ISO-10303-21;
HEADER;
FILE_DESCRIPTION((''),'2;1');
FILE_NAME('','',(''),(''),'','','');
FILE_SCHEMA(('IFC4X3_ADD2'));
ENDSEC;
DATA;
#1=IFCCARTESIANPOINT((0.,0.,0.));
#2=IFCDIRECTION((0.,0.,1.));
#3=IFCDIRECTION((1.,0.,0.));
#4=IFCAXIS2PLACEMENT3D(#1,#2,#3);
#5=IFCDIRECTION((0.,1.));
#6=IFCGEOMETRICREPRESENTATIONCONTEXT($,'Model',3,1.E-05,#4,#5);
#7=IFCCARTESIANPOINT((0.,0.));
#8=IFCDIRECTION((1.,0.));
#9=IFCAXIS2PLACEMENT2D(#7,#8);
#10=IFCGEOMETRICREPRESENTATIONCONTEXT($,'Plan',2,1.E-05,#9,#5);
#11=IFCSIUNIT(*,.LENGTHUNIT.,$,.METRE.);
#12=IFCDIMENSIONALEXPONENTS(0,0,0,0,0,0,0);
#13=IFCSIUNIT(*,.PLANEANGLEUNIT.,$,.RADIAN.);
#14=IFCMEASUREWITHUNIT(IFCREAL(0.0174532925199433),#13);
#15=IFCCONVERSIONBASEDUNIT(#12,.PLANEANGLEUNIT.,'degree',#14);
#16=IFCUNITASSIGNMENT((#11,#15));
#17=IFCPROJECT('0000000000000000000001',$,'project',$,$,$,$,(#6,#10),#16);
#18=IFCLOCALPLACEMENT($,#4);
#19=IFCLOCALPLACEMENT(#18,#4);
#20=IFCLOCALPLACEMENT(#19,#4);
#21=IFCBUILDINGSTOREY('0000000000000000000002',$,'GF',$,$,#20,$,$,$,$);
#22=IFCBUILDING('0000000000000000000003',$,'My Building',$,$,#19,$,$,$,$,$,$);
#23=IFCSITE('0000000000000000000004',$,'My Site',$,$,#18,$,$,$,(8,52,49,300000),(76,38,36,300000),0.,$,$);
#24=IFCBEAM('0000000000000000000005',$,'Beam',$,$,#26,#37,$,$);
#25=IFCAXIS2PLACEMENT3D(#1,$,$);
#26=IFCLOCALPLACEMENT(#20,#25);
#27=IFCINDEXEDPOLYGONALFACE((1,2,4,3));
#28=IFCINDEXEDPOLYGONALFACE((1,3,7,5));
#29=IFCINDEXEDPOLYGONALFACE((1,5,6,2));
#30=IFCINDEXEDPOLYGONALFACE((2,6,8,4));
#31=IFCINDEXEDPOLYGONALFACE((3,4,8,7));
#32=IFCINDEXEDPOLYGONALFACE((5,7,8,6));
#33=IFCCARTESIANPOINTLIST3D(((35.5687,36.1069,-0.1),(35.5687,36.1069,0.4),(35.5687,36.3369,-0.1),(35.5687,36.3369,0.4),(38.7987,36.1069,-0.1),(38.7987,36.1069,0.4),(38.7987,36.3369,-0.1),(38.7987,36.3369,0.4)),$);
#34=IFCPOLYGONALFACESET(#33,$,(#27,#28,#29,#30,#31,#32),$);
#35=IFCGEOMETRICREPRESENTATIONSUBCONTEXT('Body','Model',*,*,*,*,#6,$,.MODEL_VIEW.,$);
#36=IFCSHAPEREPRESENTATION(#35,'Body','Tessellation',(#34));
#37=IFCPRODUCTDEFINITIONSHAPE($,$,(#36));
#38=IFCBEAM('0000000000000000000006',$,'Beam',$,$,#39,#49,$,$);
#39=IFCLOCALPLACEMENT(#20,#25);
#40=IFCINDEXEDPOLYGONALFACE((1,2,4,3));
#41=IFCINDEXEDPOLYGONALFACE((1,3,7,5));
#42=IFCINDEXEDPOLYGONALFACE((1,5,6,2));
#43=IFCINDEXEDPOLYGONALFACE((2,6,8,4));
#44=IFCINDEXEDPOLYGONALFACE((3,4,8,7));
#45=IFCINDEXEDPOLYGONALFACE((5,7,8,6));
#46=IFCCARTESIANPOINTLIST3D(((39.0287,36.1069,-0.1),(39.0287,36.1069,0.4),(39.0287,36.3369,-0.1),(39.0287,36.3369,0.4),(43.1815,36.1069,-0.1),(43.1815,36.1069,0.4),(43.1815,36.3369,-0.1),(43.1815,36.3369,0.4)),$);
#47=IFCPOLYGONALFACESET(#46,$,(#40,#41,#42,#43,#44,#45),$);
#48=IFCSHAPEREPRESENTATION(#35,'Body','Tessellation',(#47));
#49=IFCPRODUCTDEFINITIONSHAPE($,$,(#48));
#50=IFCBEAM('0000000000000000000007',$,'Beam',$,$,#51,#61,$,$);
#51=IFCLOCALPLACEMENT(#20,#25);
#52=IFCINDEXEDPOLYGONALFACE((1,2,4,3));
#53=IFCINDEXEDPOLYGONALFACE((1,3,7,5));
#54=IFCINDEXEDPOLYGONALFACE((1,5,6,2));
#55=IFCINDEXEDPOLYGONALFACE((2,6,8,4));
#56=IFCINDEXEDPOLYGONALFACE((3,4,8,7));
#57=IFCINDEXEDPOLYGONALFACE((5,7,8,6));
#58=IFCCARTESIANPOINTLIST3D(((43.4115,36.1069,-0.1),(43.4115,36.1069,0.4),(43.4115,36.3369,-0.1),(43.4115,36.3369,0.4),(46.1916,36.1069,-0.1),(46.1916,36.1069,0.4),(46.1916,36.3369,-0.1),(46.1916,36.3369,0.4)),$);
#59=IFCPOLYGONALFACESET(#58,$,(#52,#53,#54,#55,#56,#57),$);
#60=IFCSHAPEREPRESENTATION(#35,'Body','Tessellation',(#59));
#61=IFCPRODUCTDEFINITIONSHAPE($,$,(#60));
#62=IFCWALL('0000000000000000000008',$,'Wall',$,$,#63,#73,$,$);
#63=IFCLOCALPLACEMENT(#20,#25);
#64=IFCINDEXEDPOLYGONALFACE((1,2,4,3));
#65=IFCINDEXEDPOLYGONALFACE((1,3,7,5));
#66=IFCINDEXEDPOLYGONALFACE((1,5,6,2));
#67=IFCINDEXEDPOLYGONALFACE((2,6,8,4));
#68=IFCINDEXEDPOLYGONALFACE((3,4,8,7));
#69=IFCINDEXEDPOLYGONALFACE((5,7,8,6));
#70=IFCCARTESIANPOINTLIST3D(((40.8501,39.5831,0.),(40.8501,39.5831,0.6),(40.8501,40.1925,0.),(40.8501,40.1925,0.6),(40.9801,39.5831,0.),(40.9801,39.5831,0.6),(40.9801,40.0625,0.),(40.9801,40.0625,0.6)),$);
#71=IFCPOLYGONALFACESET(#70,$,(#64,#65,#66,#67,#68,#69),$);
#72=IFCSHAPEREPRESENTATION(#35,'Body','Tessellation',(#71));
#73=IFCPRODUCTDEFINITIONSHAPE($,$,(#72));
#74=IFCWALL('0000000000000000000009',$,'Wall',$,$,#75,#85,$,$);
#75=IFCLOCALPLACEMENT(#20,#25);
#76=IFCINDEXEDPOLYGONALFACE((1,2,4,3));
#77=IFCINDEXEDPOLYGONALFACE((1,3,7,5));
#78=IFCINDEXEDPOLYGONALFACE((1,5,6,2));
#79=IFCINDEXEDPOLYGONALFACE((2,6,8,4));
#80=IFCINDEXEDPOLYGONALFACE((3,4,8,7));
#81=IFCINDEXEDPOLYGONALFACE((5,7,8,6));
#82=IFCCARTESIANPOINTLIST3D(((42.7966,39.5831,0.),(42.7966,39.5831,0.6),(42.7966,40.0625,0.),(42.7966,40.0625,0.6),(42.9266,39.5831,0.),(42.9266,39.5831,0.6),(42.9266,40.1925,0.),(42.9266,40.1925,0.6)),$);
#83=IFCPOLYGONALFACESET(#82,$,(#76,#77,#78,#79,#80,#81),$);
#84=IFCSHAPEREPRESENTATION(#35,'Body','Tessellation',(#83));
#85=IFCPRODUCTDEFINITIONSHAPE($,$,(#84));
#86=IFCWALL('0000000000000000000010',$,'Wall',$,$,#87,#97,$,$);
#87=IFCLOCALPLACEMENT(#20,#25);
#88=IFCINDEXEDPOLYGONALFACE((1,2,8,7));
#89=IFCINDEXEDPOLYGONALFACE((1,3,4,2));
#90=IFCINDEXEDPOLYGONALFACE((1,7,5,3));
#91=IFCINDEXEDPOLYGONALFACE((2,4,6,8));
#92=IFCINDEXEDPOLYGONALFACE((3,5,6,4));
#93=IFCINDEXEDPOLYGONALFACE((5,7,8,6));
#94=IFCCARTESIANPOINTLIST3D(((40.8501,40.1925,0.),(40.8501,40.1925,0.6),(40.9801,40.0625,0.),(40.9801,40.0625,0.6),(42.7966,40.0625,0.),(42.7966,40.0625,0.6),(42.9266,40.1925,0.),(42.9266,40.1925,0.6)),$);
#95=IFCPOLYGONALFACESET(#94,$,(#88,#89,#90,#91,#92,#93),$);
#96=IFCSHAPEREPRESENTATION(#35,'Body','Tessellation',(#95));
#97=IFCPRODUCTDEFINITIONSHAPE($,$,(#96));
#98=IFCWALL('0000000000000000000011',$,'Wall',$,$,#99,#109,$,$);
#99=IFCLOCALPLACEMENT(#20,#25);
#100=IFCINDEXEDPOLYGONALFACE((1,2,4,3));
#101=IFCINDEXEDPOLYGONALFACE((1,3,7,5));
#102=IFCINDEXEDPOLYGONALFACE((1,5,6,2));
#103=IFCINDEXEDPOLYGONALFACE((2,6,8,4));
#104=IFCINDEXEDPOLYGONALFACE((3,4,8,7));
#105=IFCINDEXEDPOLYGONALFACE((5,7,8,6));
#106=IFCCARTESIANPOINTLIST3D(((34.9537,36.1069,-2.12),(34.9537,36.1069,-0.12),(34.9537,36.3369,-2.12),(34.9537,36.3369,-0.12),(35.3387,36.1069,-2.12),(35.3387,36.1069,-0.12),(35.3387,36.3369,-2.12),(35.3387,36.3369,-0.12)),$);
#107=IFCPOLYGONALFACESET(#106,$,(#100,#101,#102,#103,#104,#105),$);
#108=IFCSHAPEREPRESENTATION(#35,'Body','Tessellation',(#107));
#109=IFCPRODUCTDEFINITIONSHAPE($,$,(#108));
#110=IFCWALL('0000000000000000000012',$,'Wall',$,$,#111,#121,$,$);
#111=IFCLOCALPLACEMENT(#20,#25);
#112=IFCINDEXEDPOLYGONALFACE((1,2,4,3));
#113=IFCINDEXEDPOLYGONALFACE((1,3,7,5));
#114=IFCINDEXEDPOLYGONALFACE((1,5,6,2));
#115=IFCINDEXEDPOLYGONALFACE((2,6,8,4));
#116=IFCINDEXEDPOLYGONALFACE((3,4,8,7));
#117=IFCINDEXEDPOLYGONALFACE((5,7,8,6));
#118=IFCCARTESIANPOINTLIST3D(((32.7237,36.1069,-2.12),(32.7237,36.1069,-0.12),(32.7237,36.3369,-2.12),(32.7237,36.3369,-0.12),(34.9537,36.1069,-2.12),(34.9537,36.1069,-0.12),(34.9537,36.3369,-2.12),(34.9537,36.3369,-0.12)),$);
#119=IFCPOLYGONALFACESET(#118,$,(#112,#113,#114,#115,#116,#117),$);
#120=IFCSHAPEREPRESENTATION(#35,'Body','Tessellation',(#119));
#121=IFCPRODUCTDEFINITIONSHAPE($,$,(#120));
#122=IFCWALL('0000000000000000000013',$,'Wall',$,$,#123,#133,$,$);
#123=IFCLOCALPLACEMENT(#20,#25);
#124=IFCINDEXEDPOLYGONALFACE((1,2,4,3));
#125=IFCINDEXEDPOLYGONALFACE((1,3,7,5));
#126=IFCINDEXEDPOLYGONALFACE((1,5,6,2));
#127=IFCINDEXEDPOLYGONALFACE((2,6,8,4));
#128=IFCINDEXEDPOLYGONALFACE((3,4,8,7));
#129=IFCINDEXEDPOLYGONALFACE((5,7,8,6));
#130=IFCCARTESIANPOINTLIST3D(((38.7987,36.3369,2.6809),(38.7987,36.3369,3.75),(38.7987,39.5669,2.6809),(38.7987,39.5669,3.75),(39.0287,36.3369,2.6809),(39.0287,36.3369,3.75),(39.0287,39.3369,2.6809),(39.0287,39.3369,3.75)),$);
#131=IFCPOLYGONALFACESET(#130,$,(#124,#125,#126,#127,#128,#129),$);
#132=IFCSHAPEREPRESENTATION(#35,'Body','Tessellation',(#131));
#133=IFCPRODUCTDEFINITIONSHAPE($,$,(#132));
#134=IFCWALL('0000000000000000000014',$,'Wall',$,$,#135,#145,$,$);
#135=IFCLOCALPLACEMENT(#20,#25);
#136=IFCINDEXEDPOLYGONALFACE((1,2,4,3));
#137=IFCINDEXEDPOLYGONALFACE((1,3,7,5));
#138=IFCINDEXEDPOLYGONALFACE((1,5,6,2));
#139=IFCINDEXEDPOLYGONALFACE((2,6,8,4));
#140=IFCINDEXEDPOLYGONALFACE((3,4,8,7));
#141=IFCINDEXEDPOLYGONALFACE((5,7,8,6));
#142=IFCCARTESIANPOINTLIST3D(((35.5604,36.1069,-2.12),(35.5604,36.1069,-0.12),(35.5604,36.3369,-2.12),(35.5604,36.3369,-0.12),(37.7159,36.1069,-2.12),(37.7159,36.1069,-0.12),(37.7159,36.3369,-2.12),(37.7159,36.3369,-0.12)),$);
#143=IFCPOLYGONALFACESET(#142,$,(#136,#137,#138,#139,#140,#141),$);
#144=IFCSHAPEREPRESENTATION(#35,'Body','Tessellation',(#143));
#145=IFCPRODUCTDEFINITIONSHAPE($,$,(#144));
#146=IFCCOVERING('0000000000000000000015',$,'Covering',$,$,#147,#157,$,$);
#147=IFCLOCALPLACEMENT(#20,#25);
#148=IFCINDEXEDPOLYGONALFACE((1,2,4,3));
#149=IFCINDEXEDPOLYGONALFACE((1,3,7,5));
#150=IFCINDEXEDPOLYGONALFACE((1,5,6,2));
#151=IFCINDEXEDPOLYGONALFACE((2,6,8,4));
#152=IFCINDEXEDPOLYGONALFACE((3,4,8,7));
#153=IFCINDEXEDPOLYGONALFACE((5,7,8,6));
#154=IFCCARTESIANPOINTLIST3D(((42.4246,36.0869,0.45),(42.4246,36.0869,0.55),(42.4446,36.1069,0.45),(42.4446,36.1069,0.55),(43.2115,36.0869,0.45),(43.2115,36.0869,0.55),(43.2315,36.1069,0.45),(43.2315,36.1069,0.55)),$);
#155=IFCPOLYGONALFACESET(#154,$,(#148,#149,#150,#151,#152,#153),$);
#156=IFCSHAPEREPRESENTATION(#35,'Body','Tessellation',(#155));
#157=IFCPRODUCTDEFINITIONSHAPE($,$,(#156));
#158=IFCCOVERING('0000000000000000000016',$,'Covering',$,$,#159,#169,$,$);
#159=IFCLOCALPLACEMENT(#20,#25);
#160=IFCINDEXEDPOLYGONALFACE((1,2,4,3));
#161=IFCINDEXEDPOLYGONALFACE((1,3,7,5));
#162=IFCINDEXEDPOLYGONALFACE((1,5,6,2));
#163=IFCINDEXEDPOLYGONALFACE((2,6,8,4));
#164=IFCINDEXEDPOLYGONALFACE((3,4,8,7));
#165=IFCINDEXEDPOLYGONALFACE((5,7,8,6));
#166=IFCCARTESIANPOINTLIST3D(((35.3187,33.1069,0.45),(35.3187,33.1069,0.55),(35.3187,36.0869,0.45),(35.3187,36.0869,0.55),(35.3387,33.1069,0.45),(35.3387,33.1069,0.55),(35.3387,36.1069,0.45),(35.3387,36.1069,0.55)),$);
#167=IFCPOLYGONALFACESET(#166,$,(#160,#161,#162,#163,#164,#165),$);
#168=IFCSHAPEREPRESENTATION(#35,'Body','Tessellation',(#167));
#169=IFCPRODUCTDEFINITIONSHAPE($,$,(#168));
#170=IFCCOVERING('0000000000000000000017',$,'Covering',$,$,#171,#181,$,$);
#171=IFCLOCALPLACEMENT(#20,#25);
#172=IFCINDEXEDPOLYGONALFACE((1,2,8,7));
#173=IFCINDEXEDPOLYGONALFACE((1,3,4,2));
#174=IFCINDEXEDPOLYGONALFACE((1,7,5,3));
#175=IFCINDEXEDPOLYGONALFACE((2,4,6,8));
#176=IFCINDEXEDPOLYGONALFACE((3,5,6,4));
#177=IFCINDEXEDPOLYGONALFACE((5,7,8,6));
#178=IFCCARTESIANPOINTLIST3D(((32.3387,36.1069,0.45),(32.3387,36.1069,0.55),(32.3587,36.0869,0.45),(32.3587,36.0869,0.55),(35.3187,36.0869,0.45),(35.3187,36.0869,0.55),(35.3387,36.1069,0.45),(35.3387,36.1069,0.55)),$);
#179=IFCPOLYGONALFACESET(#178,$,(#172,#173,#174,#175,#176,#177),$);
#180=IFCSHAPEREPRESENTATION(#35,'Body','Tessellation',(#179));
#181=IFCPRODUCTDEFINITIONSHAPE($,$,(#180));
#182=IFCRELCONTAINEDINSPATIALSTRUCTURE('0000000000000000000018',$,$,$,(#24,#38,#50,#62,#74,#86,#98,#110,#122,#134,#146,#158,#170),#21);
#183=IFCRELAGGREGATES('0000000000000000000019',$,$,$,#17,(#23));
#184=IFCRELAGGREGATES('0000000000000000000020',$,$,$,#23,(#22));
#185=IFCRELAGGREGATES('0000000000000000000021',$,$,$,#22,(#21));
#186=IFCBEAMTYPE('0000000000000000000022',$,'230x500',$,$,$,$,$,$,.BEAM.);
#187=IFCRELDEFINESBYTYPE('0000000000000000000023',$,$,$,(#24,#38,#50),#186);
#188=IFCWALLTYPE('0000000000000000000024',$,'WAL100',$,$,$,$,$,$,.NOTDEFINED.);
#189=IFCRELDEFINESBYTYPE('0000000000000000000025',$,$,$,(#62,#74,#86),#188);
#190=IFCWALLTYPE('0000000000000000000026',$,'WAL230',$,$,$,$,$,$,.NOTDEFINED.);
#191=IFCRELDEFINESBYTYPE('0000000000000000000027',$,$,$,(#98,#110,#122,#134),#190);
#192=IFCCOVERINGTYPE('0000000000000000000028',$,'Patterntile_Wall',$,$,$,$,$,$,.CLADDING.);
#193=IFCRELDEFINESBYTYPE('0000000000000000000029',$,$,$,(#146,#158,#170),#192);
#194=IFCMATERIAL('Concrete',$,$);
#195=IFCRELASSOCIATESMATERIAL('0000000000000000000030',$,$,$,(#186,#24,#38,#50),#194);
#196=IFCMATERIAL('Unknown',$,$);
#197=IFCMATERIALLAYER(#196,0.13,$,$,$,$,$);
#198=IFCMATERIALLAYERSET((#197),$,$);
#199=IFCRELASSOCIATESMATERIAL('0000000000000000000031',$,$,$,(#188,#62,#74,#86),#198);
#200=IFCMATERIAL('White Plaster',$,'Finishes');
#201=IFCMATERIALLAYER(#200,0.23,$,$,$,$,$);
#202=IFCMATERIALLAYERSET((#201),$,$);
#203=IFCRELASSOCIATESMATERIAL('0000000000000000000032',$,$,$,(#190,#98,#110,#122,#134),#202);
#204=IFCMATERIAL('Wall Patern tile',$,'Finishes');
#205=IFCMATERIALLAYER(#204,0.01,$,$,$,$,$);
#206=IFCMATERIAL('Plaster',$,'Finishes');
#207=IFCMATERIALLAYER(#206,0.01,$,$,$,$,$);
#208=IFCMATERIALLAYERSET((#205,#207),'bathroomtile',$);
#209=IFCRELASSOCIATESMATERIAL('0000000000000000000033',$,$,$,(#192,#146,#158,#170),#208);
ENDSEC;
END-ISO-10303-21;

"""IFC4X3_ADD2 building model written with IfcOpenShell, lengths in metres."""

from ifc_helpers import new_model, entity, si_unit, converted_unit, direction, frame, origin_with_axes, origin_2d_with_axis, place, context, subcontext, project, spatial, line, indexed_curve, rectangle, outline, extrude, material, layer, layer_set, layer_usage, material_profile, profile_set, profile_usage, type_object, element, save


model = new_model("IFC4X3_ADD2")

# Units and contexts
model_context = context("Model", 3, precision=1e-05, world=origin_with_axes(), true_north=direction((0.0, 1.0)))
plan_context = context("Plan", 2, precision=1e-05, world=origin_2d_with_axis(), true_north=direction((0.0, 1.0)))
body_context_1 = subcontext(model_context, "Body", "Model", "MODEL_VIEW")
ifc_project = project(units=[si_unit("LENGTHUNIT", "METRE"), converted_unit("PLANEANGLEUNIT", "degree", entity("IfcReal", 0.0174532925199433), si_unit("PLANEANGLEUNIT", "RADIAN"), dimensions=[0, 0, 0, 0, 0, 0, 0])], contexts=[model_context, plan_context])

# Site, building, storey
site_placement = place(None, origin_with_axes())
site = spatial("IfcSite", under=ifc_project, at=site_placement, Name="My Site", RefLatitude=(8, 52, 49, 300000), RefLongitude=(76, 38, 36, 300000), RefElevation=0.0)
building_placement = place(site_placement, origin_with_axes())
building = spatial("IfcBuilding", under=site, at=building_placement, Name="My Building")
storey_placement = place(building_placement, origin_with_axes())
storey = spatial("IfcBuildingStorey", under=building, at=storey_placement, Name="GF")

# Beams
ifc_material_1 = material(Name="Concrete")
ifc_material_profile = material_profile(ifc_material_1, rectangle(XDim=0.23, YDim=0.5))
ifc_profile_set = profile_set([ifc_material_profile])
ifc_profile_usage_1 = profile_usage(ifc_profile_set, cardinal=5)
beam_type = type_object("IfcBeamType", Name="230x500", PredefinedType="BEAM", material=ifc_profile_set)
beam_1_placement = place(storey_placement, frame((35.5687, 36.2219, 0.15), z_axis=(1.0, 0.0, 0.0), x_axis=(0.0, 1.0, 0.0)))
element("IfcBeam", 1, at=beam_1_placement, inside=storey, type_object=beam_type, material=ifc_profile_usage_1, Name="Beam", context=body_context_1, shape_type="SweptSolid", body=[
    extrude(rectangle(XDim=0.23, YDim=0.5), origin_with_axes(), (0.0, 0.0, 1.0), 3.23),
])
ifc_profile_usage_2 = profile_usage(ifc_profile_set, cardinal=5)
beam_2_placement = place(storey_placement, frame((39.0287, 36.2219, 0.15), z_axis=(1.0, 0.0, 0.0), x_axis=(0.0, 1.0, 0.0)))
element("IfcBeam", 2, at=beam_2_placement, inside=storey, type_object=beam_type, material=ifc_profile_usage_2, Name="Beam", context=body_context_1, shape_type="SweptSolid", body=[
    extrude(rectangle(XDim=0.23, YDim=0.5), origin_with_axes(), (0.0, 0.0, 1.0), 4.1528),
])
ifc_profile_usage_3 = profile_usage(ifc_profile_set, cardinal=5)
beam_3_placement = place(storey_placement, frame((43.4115, 36.2219, 0.15), z_axis=(1.0, 0.0, 0.0), x_axis=(0.0, 1.0, 0.0)))
element("IfcBeam", 3, at=beam_3_placement, inside=storey, type_object=beam_type, material=ifc_profile_usage_3, Name="Beam", context=body_context_1, shape_type="SweptSolid", body=[
    extrude(rectangle(XDim=0.23, YDim=0.5), origin_with_axes(), (0.0, 0.0, 1.0), 2.7801),
])

# Walls
ifc_material_2 = material(Name="Unknown")
ifc_layer_1 = layer(ifc_material_2, 0.13)
ifc_layer_set_1 = layer_set([ifc_layer_1])
ifc_layer_usage_1 = layer_usage(ifc_layer_set_1, "AXIS2", "POSITIVE", 0.0)
wall_type_1 = type_object("IfcWallType", Name="WAL100", PredefinedType="NOTDEFINED", material=ifc_layer_set_1)
wall_1_placement = place(storey_placement, frame((40.9801, 39.5831, 0.0), z_axis=(0.0, 0.0, 1.0), x_axis=(0.0, 1.0, 0.0)))
element("IfcWall", 4, at=wall_1_placement, inside=storey, type_object=wall_type_1, material=ifc_layer_usage_1, Name="Wall", context=body_context_1, shape_type="SweptSolid", body=[
    extrude(outline(indexed_curve([(0.0, 0.0), (0.0, 0.13), (0.6094, 0.13), (0.4794, 0.0)], segments=[line(1, 2, 3, 4, 1)])), origin_with_axes(), (0.0, 0.0, 1.0), 0.6),
])
ifc_layer_usage_2 = layer_usage(ifc_layer_set_1, "AXIS2", "POSITIVE", 0.0)
wall_2_placement = place(storey_placement, frame((42.9266, 39.5831, 0.0), z_axis=(0.0, 0.0, 1.0), x_axis=(0.0, 1.0, 0.0)))
element("IfcWall", 5, at=wall_2_placement, inside=storey, type_object=wall_type_1, material=ifc_layer_usage_2, Name="Wall", context=body_context_1, shape_type="SweptSolid", body=[
    extrude(outline(indexed_curve([(0.0, 0.0), (0.0, 0.13), (0.4794, 0.13), (0.6094, 0.0)], segments=[line(1, 2, 3, 4, 1)])), origin_with_axes(), (0.0, 0.0, 1.0), 0.6),
])
ifc_layer_usage_3 = layer_usage(ifc_layer_set_1, "AXIS2", "POSITIVE", 0.0)
wall_3_placement = place(storey_placement, frame((42.9266, 40.1925, 0.0), z_axis=(0.0, 0.0, 1.0), x_axis=(-1.0, 0.0, 0.0)))
element("IfcWall", 6, at=wall_3_placement, inside=storey, type_object=wall_type_1, material=ifc_layer_usage_3, Name="Wall", context=body_context_1, shape_type="SweptSolid", body=[
    extrude(outline(indexed_curve([(0.0, 0.0), (0.13, 0.13), (1.9464, 0.13), (2.0764, 0.0)], segments=[line(1, 2, 3, 4, 1)])), origin_with_axes(), (0.0, 0.0, 1.0), 0.6),
])

# Shared definitions
ifc_material_3 = material(Name="White Plaster", Category="Finishes")
ifc_layer_2 = layer(ifc_material_3, 0.23)
ifc_layer_set_2 = layer_set([ifc_layer_2])
wall_type_2 = type_object("IfcWallType", Name="WAL230", PredefinedType="NOTDEFINED", material=ifc_layer_set_2)

# Walls
ifc_layer_usage_4 = layer_usage(ifc_layer_set_2, "AXIS2", "POSITIVE", 0.0)
wall_4_placement = place(storey_placement, frame((35.3387, 36.3369, -2.12), z_axis=(0.0, 0.0, 1.0), x_axis=(-1.0, 0.0, 0.0)))
element("IfcWall", 7, at=wall_4_placement, inside=storey, type_object=wall_type_2, material=ifc_layer_usage_4, Name="Wall", context=body_context_1, shape_type="SweptSolid", body=[
    extrude(outline(indexed_curve([(0.0, 0.0), (0.0, 0.23), (0.385, 0.23), (0.385, 0.0)], segments=[line(1, 2, 3, 4, 1)])), origin_with_axes(), (0.0, 0.0, 1.0), 2.0),
])
ifc_layer_usage_5 = layer_usage(ifc_layer_set_2, "AXIS2", "POSITIVE", 0.0)
wall_5_placement = place(storey_placement, frame((34.9537, 36.3369, -2.12), z_axis=(0.0, 0.0, 1.0), x_axis=(-1.0, 0.0, 0.0)))
element("IfcWall", 8, at=wall_5_placement, inside=storey, type_object=wall_type_2, material=ifc_layer_usage_5, Name="Wall", context=body_context_1, shape_type="SweptSolid", body=[
    extrude(outline(indexed_curve([(0.0, 0.0), (0.0, 0.23), (2.23, 0.23), (2.23, 0.0)], segments=[line(1, 2, 3, 4, 1)])), origin_with_axes(), (0.0, 0.0, 1.0), 2.0),
])
ifc_layer_usage_6 = layer_usage(ifc_layer_set_2, "AXIS2", "POSITIVE", 0.0)
wall_6_placement = place(storey_placement, frame((39.0287, 36.3369, 2.6809), z_axis=(0.0, 0.0, 1.0), x_axis=(0.000001, 1.0, 0.0)))
element("IfcWall", 9, at=wall_6_placement, inside=storey, type_object=wall_type_2, material=ifc_layer_usage_6, Name="Wall", context=body_context_1, shape_type="SweptSolid", body=[
    extrude(outline(indexed_curve([(0.0, 0.0), (0.0, 0.23), (3.23, 0.23), (3.0, 0.0)], segments=[line(1, 2, 3, 4, 1)])), origin_with_axes(), (0.0, 0.0, 1.0), 1.0691),
])
ifc_layer_usage_7 = layer_usage(ifc_layer_set_2, "AXIS2", "POSITIVE", 0.0)
wall_7_placement = place(storey_placement, frame((37.7159, 36.3369, -2.12), z_axis=(0.0, 0.0, 1.0), x_axis=(-1.0, 0.0, 0.0)))
element("IfcWall", 10, at=wall_7_placement, inside=storey, type_object=wall_type_2, material=ifc_layer_usage_7, Name="Wall", context=body_context_1, shape_type="SweptSolid", body=[
    extrude(outline(indexed_curve([(0.0, 0.0), (0.0, 0.23), (2.1555, 0.23), (2.1555, 0.0)], segments=[line(1, 2, 3, 4, 1)])), origin_with_axes(), (0.0, 0.0, 1.0), 2.0),
])

# Coverings
ifc_material_4 = material(Name="Wall Patern tile", Category="Finishes")
ifc_layer_3 = layer(ifc_material_4, 0.01)
ifc_material_5 = material(Name="Plaster", Category="Finishes")
ifc_layer_4 = layer(ifc_material_5, 0.01)
ifc_layer_set_3 = layer_set([ifc_layer_3, ifc_layer_4], Name="bathroomtile")
ifc_layer_usage_8 = layer_usage(ifc_layer_set_3, "AXIS2", "NEGATIVE", 0.0)
covering_type = type_object("IfcCoveringType", Name="Patterntile_Wall", PredefinedType="CLADDING", material=ifc_layer_set_3)
covering_1_placement = place(storey_placement, frame((43.2115, 36.0869, 0.45), z_axis=(0.0, 0.0, 1.0), x_axis=(-1.0, 0.000001, 0.0)))
element("IfcCovering", 11, at=covering_1_placement, inside=storey, type_object=covering_type, material=ifc_layer_usage_8, Name="Covering", context=body_context_1, shape_type="SweptSolid", body=[
    extrude(outline(indexed_curve([(-0.02, -0.02), (0.0, 0.0), (0.787, 0.0), (0.767, -0.02)], segments=[line(1, 2, 3, 4, 1)])), origin_with_axes(), (0.0, 0.0, 1.0), 0.1),
])
ifc_layer_usage_9 = layer_usage(ifc_layer_set_3, "AXIS2", "NEGATIVE", 0.0)
covering_2_placement = place(storey_placement, frame((35.3187, 33.1069, 0.45), z_axis=(0.0, 0.0, 1.0), x_axis=(0.0, 1.0, 0.0)))
element("IfcCovering", 12, at=covering_2_placement, inside=storey, type_object=covering_type, material=ifc_layer_usage_9, Name="Covering", context=body_context_1, shape_type="SweptSolid", body=[
    extrude(outline(indexed_curve([(0.0, -0.02), (0.0, 0.0), (2.98, 0.0), (3.0, -0.02)], segments=[line(1, 2, 3, 4, 1)])), origin_with_axes(), (0.0, 0.0, 1.0), 0.1),
])
ifc_layer_usage_10 = layer_usage(ifc_layer_set_3, "AXIS2", "NEGATIVE", 0.0)
covering_3_placement = place(storey_placement, frame((35.3187, 36.0869, 0.45), z_axis=(0.0, 0.0, 1.0), x_axis=(-1.0, 0.000001, 0.0)))
element("IfcCovering", 13, at=covering_3_placement, inside=storey, type_object=covering_type, material=ifc_layer_usage_10, Name="Covering", context=body_context_1, shape_type="SweptSolid", body=[
    extrude(outline(indexed_curve([(-0.02, -0.02), (0.0, 0.0), (2.96, 0.0), (2.98, -0.02)], segments=[line(1, 2, 3, 4, 1)])), origin_with_axes(), (0.0, 0.0, 1.0), 0.1),
])

save(model, "model.ifc")
